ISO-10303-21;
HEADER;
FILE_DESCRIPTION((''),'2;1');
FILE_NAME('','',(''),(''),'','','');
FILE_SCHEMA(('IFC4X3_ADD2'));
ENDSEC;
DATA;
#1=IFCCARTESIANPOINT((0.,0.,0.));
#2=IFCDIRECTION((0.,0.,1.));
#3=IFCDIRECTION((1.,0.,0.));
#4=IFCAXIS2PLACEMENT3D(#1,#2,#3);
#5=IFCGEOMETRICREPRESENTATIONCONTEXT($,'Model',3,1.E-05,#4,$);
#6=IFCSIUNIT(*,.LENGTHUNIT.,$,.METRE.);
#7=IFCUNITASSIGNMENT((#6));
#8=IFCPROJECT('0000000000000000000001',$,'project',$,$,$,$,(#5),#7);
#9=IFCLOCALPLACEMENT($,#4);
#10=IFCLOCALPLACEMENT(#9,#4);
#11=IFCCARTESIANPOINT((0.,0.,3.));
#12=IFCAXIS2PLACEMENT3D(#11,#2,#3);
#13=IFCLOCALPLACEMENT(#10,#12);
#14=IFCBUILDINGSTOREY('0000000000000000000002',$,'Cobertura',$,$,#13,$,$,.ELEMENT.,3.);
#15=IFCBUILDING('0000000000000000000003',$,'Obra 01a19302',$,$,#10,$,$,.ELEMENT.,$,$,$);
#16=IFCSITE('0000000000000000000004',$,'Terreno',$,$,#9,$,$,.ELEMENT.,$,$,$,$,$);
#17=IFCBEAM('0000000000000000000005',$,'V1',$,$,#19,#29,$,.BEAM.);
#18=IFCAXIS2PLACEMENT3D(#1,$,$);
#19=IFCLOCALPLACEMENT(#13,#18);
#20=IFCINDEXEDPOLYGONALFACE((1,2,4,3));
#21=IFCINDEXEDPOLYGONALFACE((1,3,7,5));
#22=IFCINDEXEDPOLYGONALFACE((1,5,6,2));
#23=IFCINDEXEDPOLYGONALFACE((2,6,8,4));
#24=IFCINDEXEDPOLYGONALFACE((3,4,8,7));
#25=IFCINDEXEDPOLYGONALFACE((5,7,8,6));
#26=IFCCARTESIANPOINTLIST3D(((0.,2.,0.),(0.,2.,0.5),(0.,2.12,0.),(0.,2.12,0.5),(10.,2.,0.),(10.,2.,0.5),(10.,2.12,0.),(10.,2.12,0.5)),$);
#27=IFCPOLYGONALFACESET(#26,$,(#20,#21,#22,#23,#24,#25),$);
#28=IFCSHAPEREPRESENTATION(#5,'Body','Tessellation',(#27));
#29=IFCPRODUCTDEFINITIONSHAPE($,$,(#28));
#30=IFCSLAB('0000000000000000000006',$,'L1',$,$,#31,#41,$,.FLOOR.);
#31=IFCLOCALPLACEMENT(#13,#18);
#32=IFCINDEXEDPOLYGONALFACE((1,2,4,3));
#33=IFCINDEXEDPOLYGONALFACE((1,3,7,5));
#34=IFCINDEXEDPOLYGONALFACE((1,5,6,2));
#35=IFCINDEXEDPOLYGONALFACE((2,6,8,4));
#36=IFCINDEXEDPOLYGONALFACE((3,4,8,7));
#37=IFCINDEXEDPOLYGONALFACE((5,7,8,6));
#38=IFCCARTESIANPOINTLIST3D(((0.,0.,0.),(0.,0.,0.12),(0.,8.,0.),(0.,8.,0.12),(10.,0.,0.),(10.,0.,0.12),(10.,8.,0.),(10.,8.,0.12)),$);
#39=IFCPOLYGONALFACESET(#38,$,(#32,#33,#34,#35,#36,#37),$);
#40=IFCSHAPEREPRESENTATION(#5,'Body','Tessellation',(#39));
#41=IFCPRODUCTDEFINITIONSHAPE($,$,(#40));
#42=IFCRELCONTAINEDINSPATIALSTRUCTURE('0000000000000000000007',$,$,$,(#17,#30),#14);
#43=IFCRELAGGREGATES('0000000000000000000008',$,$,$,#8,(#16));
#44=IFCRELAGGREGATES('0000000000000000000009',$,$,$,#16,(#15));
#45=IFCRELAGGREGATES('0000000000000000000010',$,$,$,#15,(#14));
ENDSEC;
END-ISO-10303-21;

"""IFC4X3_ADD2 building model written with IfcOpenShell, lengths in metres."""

from ifc_helpers import new_model, si_unit, frame, frame_2d, origin_with_axes, place, context, project, spatial, polyline, rectangle, outline, extrude, element, save


model = new_model("IFC4X3_ADD2")

# Units and contexts
model_context = context("Model", 3, precision=1e-05, world=origin_with_axes())
ifc_project = project(units=[si_unit("LENGTHUNIT", "METRE")], contexts=[model_context])

# Site, building, storey
site_placement = place(None, origin_with_axes())
site = spatial("IfcSite", under=ifc_project, at=site_placement, Name="Terreno", CompositionType="ELEMENT")
building_placement = place(site_placement, origin_with_axes())
building = spatial("IfcBuilding", under=site, at=building_placement, Name="Obra 01a19302", CompositionType="ELEMENT")
storey_placement = place(building_placement, frame((0.0, 0.0, 3.0), z_axis=(0.0, 0.0, 1.0), x_axis=(1.0, 0.0, 0.0)))
storey = spatial("IfcBuildingStorey", under=building, at=storey_placement, Name="Cobertura", CompositionType="ELEMENT", Elevation=3.0)

# Beam
beam_placement = place(storey_placement, frame((0.0, 2.0, 0.0), z_axis=(0.0, 0.0, 1.0), x_axis=(1.0, 0.0, 0.0)))
element("IfcBeam", 1, at=beam_placement, inside=storey, Name="V1", PredefinedType="BEAM", context=model_context, shape_type="SweptSolid", body=[
    extrude(rectangle(XDim=10.0, YDim=0.12, at=frame_2d((5.0, 0.06))), origin_with_axes(), (0.0, 0.0, 1.0), 0.5),
])

# Slab
slab_placement = place(storey_placement, origin_with_axes())
element("IfcSlab", 2, at=slab_placement, inside=storey, Name="L1", PredefinedType="FLOOR", context=model_context, shape_type="SweptSolid", body=[
    extrude(outline(polyline([(0.0, 0.0), (10.0, 0.0), (10.0, 8.0), (0.0, 8.0), (0.0, 0.0)])), origin_with_axes(), (0.0, 0.0, 1.0), 0.12),
])

save(model, "model.ifc")
